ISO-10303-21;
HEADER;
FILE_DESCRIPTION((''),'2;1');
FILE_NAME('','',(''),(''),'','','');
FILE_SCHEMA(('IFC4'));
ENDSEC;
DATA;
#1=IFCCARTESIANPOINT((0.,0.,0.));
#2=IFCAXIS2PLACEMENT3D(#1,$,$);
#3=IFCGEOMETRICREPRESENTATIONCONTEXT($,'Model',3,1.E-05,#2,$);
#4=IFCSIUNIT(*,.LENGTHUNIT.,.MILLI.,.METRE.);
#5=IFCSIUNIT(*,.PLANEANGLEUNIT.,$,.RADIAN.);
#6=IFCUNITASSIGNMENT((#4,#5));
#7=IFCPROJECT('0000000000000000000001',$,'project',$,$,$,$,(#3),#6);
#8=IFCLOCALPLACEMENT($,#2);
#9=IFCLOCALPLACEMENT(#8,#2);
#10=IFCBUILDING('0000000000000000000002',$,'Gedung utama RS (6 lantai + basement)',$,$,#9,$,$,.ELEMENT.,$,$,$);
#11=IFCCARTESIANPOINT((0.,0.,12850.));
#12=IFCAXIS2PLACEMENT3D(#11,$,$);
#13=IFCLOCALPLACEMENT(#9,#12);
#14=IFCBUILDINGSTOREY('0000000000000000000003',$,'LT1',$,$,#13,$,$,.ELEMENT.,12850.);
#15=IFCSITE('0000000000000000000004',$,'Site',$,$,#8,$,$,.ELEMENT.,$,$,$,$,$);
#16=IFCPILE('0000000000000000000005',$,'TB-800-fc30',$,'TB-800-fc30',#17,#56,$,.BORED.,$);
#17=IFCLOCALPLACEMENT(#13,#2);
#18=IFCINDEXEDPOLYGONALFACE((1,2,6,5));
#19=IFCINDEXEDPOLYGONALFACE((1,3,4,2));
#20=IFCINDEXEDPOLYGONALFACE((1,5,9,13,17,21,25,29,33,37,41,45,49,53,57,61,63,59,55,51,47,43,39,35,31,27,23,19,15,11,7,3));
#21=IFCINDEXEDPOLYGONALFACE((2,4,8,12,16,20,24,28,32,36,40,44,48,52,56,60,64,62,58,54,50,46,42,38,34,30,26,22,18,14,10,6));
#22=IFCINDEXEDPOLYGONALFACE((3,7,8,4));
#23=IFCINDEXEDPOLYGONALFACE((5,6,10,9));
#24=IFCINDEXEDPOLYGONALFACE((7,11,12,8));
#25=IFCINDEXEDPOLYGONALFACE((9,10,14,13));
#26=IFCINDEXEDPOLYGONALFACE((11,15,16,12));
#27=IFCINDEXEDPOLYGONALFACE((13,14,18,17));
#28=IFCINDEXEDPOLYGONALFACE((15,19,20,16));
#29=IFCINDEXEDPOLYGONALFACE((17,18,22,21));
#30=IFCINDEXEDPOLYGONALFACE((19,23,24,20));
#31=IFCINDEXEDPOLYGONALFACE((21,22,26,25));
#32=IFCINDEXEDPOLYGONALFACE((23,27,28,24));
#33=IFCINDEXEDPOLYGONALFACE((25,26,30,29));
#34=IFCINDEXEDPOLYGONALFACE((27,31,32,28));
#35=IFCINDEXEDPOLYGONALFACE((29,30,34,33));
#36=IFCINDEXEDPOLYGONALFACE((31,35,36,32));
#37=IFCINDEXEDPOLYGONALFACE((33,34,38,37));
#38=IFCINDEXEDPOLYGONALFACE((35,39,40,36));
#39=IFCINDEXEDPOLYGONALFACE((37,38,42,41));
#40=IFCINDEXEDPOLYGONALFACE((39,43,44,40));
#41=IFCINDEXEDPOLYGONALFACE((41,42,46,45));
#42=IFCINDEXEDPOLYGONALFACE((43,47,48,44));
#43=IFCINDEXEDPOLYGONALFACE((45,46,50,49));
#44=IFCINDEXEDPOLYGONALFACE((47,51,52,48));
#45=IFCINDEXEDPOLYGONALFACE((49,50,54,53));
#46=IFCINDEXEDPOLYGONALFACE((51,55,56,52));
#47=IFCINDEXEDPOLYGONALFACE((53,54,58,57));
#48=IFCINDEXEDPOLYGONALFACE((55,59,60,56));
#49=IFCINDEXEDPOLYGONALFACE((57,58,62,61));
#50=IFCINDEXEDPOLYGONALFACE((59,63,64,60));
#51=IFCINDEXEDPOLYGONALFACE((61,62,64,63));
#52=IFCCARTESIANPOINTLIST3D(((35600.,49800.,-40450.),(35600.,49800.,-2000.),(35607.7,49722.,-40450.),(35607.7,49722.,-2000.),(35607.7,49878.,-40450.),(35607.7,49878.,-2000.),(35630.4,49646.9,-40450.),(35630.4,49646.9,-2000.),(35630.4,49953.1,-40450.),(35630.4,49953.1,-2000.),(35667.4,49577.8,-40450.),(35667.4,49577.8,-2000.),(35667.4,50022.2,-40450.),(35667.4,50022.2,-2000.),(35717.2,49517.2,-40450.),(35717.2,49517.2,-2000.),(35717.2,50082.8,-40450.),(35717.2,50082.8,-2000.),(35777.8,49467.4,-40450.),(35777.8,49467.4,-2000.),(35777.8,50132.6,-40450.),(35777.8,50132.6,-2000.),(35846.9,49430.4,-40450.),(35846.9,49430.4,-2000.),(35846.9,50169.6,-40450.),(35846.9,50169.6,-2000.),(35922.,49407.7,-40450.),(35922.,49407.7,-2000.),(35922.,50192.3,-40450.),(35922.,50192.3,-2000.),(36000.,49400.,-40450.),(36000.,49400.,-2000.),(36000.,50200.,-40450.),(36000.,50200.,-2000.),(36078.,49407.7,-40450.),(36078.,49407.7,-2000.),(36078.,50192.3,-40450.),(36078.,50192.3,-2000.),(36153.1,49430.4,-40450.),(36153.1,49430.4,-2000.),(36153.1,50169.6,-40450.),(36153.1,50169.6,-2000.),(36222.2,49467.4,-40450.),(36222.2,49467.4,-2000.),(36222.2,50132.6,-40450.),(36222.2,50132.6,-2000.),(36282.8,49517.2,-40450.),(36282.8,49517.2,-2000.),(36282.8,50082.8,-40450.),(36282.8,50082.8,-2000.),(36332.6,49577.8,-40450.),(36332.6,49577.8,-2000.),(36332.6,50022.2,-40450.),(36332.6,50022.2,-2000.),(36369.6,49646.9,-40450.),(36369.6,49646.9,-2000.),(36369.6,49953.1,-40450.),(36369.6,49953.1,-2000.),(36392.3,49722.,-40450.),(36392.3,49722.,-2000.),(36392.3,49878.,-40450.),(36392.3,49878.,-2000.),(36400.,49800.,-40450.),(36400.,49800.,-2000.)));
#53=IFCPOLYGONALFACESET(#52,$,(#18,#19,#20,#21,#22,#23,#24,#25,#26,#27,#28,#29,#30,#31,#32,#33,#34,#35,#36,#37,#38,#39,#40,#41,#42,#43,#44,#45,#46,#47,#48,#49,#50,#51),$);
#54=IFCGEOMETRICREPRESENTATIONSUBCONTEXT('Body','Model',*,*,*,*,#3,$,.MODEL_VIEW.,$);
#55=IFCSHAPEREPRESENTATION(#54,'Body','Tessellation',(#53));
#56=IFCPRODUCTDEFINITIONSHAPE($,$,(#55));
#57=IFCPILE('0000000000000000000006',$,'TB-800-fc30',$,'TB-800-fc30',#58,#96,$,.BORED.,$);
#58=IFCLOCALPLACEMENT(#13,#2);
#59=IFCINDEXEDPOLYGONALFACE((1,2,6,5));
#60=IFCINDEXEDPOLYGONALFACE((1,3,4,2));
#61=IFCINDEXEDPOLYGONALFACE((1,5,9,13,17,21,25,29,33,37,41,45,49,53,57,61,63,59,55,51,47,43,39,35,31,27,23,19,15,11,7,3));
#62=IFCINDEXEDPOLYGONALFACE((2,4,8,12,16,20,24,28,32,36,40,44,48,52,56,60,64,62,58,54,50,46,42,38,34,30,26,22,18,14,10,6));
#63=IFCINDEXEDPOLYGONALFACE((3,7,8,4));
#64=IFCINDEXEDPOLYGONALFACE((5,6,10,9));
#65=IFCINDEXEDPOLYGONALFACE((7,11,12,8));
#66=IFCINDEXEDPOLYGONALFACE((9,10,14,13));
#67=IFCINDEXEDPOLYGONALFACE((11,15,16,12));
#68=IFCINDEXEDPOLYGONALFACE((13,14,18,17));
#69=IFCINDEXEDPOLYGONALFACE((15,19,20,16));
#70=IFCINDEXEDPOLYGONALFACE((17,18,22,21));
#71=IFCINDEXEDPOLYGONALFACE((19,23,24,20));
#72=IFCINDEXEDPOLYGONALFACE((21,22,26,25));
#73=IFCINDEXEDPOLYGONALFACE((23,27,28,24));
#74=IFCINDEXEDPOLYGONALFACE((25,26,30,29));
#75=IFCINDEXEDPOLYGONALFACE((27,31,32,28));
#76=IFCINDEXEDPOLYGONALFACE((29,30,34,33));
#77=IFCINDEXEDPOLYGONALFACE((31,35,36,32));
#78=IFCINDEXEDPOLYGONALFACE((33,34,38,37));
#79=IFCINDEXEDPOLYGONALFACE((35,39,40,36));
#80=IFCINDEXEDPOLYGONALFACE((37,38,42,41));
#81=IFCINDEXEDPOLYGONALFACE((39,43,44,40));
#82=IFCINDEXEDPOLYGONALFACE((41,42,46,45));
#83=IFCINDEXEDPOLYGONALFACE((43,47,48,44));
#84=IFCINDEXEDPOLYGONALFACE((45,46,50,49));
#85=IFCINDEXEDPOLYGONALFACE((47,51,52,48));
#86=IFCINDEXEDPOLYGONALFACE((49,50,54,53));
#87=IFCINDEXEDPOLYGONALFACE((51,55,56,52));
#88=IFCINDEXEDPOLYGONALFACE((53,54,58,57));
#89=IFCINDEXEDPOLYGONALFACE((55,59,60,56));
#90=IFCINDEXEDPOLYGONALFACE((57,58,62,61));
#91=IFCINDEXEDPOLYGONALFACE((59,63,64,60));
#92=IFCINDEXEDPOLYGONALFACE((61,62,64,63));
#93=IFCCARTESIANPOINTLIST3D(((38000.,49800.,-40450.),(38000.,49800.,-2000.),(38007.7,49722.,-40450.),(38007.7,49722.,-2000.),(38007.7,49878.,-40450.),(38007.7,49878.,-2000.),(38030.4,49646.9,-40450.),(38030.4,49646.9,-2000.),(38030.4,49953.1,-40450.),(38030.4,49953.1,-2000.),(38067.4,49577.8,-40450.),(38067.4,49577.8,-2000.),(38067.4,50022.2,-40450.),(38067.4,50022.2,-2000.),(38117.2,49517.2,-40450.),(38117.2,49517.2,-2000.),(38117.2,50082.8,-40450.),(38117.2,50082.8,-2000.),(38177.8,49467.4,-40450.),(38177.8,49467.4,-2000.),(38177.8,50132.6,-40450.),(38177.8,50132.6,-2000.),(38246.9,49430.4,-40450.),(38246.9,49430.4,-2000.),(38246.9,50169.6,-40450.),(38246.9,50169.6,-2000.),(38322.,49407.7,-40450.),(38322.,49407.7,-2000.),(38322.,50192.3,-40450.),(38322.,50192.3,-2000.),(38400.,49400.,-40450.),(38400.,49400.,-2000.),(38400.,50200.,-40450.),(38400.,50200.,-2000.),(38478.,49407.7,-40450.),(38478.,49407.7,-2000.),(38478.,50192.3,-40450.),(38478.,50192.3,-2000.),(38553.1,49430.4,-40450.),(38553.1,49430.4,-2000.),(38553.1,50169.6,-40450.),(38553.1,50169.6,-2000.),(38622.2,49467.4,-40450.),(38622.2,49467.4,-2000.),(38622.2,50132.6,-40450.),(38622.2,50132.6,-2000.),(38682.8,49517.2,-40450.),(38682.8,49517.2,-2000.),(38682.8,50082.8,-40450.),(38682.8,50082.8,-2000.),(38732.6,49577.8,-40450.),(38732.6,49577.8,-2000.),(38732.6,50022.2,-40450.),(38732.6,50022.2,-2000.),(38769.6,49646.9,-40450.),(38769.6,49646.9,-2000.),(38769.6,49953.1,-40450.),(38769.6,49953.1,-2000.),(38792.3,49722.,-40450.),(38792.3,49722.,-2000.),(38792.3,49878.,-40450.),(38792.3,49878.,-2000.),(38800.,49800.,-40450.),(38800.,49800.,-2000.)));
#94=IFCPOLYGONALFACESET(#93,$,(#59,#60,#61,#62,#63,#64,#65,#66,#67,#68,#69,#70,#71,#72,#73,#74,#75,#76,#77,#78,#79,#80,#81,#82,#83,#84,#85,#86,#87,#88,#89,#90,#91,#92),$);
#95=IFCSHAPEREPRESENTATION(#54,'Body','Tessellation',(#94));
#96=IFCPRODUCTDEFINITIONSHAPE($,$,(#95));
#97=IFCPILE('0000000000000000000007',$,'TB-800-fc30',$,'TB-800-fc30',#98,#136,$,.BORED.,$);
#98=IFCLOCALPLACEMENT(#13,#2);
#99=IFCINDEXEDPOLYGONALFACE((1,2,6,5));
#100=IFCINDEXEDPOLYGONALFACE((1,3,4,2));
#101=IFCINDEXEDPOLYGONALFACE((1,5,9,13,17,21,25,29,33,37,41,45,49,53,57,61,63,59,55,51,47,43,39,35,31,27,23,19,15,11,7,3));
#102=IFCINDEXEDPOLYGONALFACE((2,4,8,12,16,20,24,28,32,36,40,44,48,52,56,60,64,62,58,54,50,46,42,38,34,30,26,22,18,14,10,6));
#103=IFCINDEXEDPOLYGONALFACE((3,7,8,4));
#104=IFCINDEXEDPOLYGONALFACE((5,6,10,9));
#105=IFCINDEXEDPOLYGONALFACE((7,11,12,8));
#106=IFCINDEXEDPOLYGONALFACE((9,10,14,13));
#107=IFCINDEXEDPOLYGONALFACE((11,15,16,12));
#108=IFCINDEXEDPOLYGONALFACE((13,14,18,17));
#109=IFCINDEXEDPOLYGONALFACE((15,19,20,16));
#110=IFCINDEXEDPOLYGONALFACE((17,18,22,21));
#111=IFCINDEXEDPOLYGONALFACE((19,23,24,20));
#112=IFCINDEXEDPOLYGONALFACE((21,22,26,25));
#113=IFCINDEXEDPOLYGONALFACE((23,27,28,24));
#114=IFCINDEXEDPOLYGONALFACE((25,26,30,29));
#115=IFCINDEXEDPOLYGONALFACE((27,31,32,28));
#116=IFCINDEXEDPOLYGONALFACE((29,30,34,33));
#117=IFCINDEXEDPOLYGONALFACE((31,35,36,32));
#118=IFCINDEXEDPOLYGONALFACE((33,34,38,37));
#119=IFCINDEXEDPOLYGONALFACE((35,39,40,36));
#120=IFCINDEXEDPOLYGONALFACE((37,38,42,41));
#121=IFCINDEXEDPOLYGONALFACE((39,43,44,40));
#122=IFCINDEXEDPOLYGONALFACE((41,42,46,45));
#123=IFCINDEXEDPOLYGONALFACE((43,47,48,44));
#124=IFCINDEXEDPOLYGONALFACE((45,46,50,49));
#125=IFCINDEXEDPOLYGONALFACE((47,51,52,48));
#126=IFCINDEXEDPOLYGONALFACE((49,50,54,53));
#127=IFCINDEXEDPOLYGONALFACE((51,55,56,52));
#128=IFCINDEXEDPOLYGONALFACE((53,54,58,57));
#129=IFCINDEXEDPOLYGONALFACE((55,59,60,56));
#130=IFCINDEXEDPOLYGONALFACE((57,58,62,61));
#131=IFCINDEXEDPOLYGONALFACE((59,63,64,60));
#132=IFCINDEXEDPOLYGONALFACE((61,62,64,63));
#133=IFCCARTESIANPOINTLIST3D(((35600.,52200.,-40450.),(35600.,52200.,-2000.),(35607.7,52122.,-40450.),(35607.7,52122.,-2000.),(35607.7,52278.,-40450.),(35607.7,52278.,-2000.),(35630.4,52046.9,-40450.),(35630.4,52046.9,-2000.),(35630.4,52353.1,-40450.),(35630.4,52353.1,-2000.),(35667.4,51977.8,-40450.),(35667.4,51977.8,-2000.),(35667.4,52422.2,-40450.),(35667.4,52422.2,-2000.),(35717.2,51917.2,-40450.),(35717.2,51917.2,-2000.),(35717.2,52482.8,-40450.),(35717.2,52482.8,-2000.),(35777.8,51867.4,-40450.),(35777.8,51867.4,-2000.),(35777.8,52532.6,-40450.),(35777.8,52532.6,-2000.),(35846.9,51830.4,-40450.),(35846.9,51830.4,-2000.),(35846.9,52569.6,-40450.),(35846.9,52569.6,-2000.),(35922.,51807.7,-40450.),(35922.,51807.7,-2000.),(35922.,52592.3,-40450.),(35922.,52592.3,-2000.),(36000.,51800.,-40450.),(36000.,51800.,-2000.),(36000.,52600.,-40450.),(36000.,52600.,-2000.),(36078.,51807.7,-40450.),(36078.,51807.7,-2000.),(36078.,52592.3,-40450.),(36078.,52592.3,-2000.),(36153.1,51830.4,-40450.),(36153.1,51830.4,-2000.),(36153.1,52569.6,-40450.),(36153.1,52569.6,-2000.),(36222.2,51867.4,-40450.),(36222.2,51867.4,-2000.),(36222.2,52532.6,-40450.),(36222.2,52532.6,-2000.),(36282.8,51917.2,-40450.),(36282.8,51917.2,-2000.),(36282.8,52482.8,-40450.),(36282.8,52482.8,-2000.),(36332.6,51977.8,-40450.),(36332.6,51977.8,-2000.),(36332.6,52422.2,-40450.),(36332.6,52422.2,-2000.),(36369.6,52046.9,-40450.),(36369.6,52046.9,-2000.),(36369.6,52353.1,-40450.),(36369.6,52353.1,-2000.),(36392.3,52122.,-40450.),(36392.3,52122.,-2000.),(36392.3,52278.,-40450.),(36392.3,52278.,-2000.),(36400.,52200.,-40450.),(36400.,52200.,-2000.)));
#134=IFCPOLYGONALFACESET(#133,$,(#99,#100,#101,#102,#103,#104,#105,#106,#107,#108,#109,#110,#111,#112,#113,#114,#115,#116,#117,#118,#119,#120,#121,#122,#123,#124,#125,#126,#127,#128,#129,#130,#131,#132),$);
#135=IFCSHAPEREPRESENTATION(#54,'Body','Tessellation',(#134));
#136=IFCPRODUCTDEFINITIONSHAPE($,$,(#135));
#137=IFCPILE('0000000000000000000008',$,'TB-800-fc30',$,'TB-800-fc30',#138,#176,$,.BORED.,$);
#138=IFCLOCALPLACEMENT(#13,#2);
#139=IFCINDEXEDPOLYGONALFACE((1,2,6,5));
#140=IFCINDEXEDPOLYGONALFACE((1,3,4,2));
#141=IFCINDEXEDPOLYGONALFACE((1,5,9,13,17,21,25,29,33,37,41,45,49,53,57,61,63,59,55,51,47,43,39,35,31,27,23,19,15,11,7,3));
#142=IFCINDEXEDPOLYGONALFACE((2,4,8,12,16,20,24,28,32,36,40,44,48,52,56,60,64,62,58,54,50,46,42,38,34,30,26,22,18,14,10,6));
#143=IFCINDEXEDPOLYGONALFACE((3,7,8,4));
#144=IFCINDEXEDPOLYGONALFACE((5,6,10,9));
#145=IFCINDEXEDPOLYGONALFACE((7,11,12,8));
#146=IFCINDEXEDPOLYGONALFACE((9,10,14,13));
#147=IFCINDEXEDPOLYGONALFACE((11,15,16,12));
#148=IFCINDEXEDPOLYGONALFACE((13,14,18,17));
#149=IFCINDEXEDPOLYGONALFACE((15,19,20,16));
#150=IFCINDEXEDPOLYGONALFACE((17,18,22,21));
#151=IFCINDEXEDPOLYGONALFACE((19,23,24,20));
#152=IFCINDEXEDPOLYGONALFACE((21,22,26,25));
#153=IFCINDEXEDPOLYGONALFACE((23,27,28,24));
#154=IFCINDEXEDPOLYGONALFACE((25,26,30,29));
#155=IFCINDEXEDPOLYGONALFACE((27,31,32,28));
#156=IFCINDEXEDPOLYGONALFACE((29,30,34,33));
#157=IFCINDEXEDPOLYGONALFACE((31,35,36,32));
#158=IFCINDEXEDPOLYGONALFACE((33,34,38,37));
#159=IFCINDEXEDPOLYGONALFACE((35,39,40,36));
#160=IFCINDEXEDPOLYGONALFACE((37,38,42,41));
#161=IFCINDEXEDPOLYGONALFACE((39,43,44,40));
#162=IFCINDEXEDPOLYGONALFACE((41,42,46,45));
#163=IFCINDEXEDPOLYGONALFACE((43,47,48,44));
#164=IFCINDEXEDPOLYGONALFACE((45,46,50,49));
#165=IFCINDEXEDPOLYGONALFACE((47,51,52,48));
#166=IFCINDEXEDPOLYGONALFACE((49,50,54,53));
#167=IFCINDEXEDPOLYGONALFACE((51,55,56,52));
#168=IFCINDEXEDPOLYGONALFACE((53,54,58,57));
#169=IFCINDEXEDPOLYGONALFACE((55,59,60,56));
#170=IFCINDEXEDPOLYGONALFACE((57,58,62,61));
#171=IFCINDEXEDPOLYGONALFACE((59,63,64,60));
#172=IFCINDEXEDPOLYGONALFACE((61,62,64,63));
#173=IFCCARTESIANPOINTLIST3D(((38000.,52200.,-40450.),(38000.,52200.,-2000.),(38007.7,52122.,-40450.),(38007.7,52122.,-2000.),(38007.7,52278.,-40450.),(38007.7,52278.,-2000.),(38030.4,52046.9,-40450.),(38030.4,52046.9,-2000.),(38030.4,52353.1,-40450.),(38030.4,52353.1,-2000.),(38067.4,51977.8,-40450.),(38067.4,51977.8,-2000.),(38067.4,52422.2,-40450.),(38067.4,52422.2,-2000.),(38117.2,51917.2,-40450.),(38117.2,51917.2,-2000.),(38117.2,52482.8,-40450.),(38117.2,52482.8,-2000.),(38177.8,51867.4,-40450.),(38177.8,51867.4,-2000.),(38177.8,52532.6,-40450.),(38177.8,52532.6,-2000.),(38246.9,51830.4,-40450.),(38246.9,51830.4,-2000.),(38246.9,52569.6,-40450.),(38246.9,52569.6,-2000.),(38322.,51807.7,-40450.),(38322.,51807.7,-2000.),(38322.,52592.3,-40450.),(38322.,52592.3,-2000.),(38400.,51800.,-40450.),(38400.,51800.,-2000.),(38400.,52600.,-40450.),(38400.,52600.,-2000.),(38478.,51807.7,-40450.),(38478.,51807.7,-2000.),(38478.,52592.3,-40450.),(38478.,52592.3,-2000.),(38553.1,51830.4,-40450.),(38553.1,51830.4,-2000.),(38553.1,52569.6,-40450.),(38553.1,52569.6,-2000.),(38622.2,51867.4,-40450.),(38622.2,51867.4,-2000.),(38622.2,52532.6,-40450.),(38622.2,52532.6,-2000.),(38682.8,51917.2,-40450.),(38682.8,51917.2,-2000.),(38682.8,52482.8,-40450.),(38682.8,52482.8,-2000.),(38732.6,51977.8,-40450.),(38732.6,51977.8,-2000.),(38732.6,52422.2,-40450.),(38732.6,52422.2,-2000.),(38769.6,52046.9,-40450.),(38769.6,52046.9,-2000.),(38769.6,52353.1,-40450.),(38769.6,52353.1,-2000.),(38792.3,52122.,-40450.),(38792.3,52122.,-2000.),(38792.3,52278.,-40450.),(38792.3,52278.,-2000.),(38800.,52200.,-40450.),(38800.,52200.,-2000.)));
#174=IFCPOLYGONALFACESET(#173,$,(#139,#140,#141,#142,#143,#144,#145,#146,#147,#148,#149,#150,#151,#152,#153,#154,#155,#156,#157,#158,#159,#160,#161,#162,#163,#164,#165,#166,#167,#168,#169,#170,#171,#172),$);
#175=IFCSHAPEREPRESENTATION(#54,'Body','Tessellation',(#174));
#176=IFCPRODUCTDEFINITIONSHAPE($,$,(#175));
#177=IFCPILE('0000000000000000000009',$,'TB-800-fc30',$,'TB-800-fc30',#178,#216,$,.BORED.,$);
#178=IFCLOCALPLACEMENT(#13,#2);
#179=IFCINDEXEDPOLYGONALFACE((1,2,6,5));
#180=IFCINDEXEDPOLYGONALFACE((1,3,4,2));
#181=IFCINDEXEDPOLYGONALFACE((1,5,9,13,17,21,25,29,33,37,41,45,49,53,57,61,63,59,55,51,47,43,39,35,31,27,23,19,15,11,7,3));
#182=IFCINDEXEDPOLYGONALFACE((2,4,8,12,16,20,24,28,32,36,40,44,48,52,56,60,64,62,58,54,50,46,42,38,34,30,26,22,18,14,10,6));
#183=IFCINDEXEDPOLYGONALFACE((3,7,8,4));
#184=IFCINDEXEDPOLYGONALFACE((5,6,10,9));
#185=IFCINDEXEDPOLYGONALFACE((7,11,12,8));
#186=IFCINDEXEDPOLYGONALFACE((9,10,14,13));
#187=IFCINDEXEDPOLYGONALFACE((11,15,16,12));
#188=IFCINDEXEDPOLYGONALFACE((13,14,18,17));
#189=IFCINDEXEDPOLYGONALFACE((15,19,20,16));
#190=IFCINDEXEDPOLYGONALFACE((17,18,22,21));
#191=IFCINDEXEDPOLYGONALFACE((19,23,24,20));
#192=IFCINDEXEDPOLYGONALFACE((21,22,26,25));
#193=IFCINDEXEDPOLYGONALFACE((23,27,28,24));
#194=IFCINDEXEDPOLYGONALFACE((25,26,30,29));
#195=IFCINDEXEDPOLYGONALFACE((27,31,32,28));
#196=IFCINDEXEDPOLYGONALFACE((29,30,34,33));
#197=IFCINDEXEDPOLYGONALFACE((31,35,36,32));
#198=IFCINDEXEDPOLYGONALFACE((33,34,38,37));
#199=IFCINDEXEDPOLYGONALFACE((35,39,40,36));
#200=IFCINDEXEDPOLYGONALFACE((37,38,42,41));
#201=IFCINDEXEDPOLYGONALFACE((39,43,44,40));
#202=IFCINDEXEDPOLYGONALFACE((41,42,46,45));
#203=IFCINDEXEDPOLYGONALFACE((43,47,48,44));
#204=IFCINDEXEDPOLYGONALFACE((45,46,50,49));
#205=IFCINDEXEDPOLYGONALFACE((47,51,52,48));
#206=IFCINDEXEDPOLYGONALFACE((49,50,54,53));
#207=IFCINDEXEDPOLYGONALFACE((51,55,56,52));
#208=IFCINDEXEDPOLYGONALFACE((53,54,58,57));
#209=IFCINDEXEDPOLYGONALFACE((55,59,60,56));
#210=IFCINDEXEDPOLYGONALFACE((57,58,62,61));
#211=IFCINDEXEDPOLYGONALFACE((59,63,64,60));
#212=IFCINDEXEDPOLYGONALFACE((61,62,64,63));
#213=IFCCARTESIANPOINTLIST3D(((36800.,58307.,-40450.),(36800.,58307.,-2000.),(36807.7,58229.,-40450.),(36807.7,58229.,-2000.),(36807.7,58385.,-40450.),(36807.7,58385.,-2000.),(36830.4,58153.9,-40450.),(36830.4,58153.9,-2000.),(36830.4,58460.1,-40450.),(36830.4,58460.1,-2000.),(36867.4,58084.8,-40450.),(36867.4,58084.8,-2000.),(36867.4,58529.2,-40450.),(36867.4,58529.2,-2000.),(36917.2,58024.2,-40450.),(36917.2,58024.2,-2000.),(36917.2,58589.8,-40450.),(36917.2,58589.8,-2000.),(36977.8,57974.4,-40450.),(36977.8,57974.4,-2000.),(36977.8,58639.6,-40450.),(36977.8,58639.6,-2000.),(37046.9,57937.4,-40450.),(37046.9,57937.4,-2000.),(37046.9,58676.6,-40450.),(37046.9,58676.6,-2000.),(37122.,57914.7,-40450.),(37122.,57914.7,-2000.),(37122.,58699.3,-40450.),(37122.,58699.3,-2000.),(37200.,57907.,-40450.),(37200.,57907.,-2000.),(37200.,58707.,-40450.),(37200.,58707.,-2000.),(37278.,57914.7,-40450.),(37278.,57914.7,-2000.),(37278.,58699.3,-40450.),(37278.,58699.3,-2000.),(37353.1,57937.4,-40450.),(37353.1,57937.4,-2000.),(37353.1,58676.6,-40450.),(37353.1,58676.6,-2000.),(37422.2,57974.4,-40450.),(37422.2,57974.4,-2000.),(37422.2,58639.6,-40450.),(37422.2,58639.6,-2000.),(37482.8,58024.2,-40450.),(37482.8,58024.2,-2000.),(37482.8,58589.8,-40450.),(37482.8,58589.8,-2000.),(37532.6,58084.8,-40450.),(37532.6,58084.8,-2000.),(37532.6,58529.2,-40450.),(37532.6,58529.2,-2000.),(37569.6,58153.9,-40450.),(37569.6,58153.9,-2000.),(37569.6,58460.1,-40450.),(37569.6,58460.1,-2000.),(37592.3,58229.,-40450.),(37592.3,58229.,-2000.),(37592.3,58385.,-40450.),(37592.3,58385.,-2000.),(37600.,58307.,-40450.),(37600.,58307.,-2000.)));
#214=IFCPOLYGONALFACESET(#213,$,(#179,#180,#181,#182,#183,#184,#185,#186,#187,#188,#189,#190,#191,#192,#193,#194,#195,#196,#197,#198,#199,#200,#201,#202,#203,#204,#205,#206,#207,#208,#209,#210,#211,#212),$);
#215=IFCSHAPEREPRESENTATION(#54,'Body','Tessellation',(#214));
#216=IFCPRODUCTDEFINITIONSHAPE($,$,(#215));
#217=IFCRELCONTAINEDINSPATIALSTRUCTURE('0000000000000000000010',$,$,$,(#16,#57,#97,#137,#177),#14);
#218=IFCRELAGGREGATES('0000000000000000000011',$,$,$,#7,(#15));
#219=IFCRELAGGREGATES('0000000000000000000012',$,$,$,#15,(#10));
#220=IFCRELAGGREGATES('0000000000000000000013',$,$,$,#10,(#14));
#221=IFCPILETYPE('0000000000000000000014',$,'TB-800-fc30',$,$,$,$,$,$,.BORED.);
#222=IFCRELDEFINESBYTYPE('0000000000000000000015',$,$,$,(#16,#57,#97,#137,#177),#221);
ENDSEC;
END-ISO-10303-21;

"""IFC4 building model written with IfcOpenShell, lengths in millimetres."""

from ifc_helpers import new_model, si_unit, frame, origin, origin_2d, place, context, subcontext, project, spatial, circle, extrude, material_profile, profile_set, profile_usage, type_object, element, save


model = new_model("IFC4")

# Units and contexts
model_context = context("Model", 3, precision=1e-05, world=origin())
body_context = subcontext(model_context, "Body", "Model", "MODEL_VIEW")
ifc_project = project(units=[si_unit("LENGTHUNIT", "METRE", prefix="MILLI"), si_unit("PLANEANGLEUNIT", "RADIAN")], contexts=[model_context])

# Site, building, storey
site_placement = place(None, origin())
site = spatial("IfcSite", under=ifc_project, at=site_placement, Name="Site", CompositionType="ELEMENT")
building_placement = place(site_placement, origin())
building = spatial("IfcBuilding", under=site, at=building_placement, Name="Gedung utama RS (6 lantai + basement)", CompositionType="ELEMENT")
storey_placement = place(building_placement, frame((0.0, 0.0, 12850.0)))
storey = spatial("IfcBuildingStorey", under=building, at=storey_placement, Name="LT1", CompositionType="ELEMENT", Elevation=12850.0)

# Piles
ifc_material_profile = material_profile(None, circle(Radius=400.0, at=origin_2d()), Name="TB-800-fc30")
ifc_profile_set = profile_set([ifc_material_profile], Name="TB-800-fc30")
ifc_profile_usage = profile_usage(ifc_profile_set, cardinal=5)
pile_type = type_object("IfcPileType", Name="TB-800-fc30", PredefinedType="BORED", material=ifc_profile_set)
for number, where, z_axis, x_axis, name in (
    (1, (36000.0, 49800.0, -40450.0), (0.0, 0.0, 1.0), (1.0, 0.0, 0.0), "TB-800-fc30"),
    (2, (38400.0, 49800.0, -40450.0), (0.0, 0.0, 1.0), (1.0, 0.0, 0.0), "TB-800-fc30"),
    (3, (36000.0, 52200.0, -40450.0), (0.0, 0.0, 1.0), (1.0, 0.0, 0.0), "TB-800-fc30"),
    (4, (38400.0, 52200.0, -40450.0), (0.0, 0.0, 1.0), (1.0, 0.0, 0.0), "TB-800-fc30"),
    (5, (37200.0, 58307.0, -40450.0), (0.0, 0.0, 1.0), (1.0, 0.0, 0.0), "TB-800-fc30"),
):
    element("IfcPile", number, at=place(storey_placement, frame(where, z_axis=z_axis, x_axis=x_axis)), inside=storey, type_object=pile_type, material=ifc_profile_usage, Name=name, ObjectType="TB-800-fc30", PredefinedType="BORED", context=body_context, shape_type="SweptSolid", body=[
        extrude(circle(Radius=400.0, at=origin_2d()), origin(), (0.0, 0.0, 1.0), 38450.0),
    ])

save(model, "model.ifc")
